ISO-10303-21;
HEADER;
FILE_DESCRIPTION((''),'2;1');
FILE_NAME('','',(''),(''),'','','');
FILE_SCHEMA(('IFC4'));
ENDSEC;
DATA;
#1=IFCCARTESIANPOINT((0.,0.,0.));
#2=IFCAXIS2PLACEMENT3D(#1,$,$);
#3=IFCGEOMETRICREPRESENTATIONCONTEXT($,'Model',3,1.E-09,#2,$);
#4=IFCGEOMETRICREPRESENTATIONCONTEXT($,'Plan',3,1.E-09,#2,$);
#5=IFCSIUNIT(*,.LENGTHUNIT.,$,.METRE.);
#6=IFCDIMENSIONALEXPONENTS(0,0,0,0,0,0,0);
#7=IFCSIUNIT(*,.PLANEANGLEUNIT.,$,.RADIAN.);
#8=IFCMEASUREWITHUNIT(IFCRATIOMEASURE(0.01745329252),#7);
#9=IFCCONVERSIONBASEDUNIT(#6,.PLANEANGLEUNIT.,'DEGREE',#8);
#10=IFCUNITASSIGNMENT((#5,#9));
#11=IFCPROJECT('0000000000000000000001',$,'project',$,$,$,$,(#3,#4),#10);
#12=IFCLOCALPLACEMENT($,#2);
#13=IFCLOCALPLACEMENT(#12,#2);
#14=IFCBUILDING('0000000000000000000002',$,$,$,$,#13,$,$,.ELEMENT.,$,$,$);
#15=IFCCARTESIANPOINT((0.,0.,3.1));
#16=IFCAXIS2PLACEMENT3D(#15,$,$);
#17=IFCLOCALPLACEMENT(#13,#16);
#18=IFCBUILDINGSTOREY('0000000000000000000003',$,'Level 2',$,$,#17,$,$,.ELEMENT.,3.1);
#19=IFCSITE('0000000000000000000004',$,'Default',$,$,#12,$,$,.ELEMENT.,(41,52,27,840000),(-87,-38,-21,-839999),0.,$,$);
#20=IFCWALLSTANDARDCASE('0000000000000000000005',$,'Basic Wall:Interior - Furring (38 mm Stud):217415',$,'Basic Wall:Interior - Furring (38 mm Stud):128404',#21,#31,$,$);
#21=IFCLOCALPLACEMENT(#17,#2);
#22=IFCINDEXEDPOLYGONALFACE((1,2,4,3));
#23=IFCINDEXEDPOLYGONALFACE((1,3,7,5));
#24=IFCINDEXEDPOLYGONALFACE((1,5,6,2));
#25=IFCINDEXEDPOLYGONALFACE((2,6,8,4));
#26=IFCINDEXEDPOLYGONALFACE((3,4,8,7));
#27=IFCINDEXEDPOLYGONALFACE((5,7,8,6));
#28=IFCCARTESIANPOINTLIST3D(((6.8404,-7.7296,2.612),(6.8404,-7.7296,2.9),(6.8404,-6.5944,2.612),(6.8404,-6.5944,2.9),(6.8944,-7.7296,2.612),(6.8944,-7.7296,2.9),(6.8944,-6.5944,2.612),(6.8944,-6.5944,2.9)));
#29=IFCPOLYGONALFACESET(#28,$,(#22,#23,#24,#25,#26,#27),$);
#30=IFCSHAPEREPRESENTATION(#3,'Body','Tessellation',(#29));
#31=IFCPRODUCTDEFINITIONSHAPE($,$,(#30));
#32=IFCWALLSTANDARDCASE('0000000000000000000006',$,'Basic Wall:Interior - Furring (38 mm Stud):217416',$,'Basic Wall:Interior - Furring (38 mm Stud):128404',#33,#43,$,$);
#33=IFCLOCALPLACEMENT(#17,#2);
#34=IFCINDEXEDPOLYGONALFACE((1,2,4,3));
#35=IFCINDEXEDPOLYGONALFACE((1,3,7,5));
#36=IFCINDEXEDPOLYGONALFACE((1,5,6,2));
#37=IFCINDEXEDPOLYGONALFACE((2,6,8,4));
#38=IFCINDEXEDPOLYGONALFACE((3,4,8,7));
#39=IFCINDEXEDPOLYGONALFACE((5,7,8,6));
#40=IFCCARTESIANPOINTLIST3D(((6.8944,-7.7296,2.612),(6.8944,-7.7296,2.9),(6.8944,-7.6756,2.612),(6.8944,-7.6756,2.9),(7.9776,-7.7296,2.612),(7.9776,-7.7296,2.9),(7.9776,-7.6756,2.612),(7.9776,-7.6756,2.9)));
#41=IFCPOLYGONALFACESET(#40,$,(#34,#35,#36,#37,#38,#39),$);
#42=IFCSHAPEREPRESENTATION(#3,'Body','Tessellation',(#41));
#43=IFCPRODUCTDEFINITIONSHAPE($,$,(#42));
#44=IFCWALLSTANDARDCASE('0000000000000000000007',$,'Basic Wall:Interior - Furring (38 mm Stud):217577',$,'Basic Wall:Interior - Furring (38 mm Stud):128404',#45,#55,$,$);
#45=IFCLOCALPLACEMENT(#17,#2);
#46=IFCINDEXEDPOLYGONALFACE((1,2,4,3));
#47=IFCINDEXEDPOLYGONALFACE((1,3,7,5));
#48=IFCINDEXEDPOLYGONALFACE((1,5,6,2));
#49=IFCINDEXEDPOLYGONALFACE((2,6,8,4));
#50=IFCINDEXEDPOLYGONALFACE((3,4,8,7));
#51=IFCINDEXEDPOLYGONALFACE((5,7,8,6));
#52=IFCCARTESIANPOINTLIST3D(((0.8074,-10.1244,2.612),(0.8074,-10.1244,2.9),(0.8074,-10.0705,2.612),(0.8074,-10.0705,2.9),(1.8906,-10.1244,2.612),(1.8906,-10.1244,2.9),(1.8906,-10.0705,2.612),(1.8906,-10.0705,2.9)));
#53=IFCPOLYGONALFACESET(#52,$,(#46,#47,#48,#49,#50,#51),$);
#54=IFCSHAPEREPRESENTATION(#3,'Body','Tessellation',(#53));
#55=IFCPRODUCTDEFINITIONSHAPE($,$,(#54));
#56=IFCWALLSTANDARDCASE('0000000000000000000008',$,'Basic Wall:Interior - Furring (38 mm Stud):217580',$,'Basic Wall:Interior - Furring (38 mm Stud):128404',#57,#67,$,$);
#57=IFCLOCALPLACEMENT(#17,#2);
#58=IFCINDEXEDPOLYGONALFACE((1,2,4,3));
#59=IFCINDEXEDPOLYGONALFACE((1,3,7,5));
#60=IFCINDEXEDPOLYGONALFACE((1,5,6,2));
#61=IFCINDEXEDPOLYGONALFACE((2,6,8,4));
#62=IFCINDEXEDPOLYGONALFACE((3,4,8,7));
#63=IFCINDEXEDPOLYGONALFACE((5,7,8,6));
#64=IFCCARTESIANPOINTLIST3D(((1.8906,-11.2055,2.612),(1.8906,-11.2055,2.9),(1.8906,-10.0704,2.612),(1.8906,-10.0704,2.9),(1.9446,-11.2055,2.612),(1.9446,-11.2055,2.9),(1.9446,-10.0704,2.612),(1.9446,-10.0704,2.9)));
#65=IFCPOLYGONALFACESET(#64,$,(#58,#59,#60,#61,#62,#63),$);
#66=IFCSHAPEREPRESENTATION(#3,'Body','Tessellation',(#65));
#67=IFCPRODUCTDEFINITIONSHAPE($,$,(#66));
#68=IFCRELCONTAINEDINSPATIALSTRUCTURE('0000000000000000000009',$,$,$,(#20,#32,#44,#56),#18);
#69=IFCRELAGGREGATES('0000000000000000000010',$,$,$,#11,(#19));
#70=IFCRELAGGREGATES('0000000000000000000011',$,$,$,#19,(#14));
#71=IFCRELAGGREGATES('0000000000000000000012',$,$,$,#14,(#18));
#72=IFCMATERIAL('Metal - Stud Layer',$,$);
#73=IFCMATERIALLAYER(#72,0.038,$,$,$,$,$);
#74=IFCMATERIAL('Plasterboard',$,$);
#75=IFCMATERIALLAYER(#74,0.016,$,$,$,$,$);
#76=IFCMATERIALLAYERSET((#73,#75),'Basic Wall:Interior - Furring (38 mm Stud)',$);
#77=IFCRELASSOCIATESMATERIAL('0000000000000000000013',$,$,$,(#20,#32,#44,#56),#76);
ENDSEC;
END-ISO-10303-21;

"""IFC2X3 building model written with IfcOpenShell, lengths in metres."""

from ifc_helpers import new_model, entity, si_unit, converted_unit, frame, frame_2d, origin, place, context, project, spatial, rectangle, extrude, material, layer, layer_set, layer_usage, element, save


model = new_model("IFC2X3")

# Units and contexts
model_context = context("Model", 3, precision=1e-09, world=origin())
plan_context = context("Plan", 3, precision=1e-09, world=origin())
ifc_project = project(units=[si_unit("LENGTHUNIT", "METRE"), converted_unit("PLANEANGLEUNIT", "DEGREE", entity("IfcRatioMeasure", 0.01745329252), si_unit("PLANEANGLEUNIT", "RADIAN"), dimensions=[0, 0, 0, 0, 0, 0, 0])], contexts=[model_context, plan_context])

# Site, building, storey
site_placement = place(None, origin())
site = spatial("IfcSite", under=ifc_project, at=site_placement, Name="Default", CompositionType="ELEMENT", RefLatitude=(41, 52, 27, 840000), RefLongitude=(-87, -38, -21, -839999), RefElevation=0.0)
building_placement = place(site_placement, origin())
building = spatial("IfcBuilding", under=site, at=building_placement, CompositionType="ELEMENT")
storey_placement = place(building_placement, frame((0.0, 0.0, 3.1)))
storey = spatial("IfcBuildingStorey", under=building, at=storey_placement, Name="Level 2", CompositionType="ELEMENT", Elevation=3.1)

# Shared definitions
ifc_material_1 = material(Name="Plasterboard")
ifc_material_2 = material(Name="Metal - Stud Layer")

# Walls
ifc_layer_1 = layer(ifc_material_2, 0.038)
ifc_layer_2 = layer(ifc_material_1, 0.016)
ifc_layer_set_1 = layer_set([ifc_layer_1, ifc_layer_2], Name="Basic Wall:Interior - Furring (38 mm Stud)")
ifc_layer_usage_1 = layer_usage(ifc_layer_set_1, "AXIS2", "NEGATIVE", 0.027)
wall_1_placement = place(storey_placement, frame((6.8674, -7.7295, 2.612), z_axis=(0.0, 0.0, 1.0), x_axis=(0.0, 1.0, 0.0)))
element("IfcWallStandardCase", 1, at=wall_1_placement, inside=storey, material=ifc_layer_usage_1, Name="Basic Wall:Interior - Furring (38 mm Stud):217415", ObjectType="Basic Wall:Interior - Furring (38 mm Stud):128404", context=model_context, shape_type="SweptSolid", body=[
    extrude(rectangle(XDim=1.1351, YDim=0.054, at=frame_2d((0.5675, 0.0), x_axis=(-1.0, 0.0))), origin(), (0.0, 0.0, 1.0), 0.288),
])
ifc_layer_usage_2 = layer_usage(ifc_layer_set_1, "AXIS2", "NEGATIVE", 0.027)
wall_2_placement = place(storey_placement, frame((7.9775, -7.7025, 2.612), z_axis=(0.0, 0.0, 1.0), x_axis=(-1.0, 0.0, 0.0)))
element("IfcWallStandardCase", 2, at=wall_2_placement, inside=storey, material=ifc_layer_usage_2, Name="Basic Wall:Interior - Furring (38 mm Stud):217416", ObjectType="Basic Wall:Interior - Furring (38 mm Stud):128404", context=model_context, shape_type="SweptSolid", body=[
    extrude(rectangle(XDim=1.0831, YDim=0.054, at=frame_2d((0.5415, 0.0), x_axis=(-1.0, 0.0))), origin(), (0.0, 0.0, 1.0), 0.288),
])
ifc_layer_usage_3 = layer_usage(ifc_layer_set_1, "AXIS2", "NEGATIVE", 0.027)
wall_3_placement = place(storey_placement, frame((0.8075, -10.0975, 2.612)))
element("IfcWallStandardCase", 3, at=wall_3_placement, inside=storey, material=ifc_layer_usage_3, Name="Basic Wall:Interior - Furring (38 mm Stud):217577", ObjectType="Basic Wall:Interior - Furring (38 mm Stud):128404", context=model_context, shape_type="SweptSolid", body=[
    extrude(rectangle(XDim=1.0831, YDim=0.054, at=frame_2d((0.5415, 0.0), x_axis=(-1.0, 0.0))), origin(), (0.0, 0.0, 1.0), 0.288),
])
ifc_layer_usage_4 = layer_usage(ifc_layer_set_1, "AXIS2", "NEGATIVE", 0.027)
wall_4_placement = place(storey_placement, frame((1.9176, -10.0704, 2.612), z_axis=(0.0, 0.0, 1.0), x_axis=(0.0, -1.0, 0.0)))
element("IfcWallStandardCase", 4, at=wall_4_placement, inside=storey, material=ifc_layer_usage_4, Name="Basic Wall:Interior - Furring (38 mm Stud):217580", ObjectType="Basic Wall:Interior - Furring (38 mm Stud):128404", context=model_context, shape_type="SweptSolid", body=[
    extrude(rectangle(XDim=1.1351, YDim=0.054, at=frame_2d((0.5675, 0.0), x_axis=(-1.0, 0.0))), origin(), (0.0, 0.0, 1.0), 0.288),
])

save(model, "model.ifc")
